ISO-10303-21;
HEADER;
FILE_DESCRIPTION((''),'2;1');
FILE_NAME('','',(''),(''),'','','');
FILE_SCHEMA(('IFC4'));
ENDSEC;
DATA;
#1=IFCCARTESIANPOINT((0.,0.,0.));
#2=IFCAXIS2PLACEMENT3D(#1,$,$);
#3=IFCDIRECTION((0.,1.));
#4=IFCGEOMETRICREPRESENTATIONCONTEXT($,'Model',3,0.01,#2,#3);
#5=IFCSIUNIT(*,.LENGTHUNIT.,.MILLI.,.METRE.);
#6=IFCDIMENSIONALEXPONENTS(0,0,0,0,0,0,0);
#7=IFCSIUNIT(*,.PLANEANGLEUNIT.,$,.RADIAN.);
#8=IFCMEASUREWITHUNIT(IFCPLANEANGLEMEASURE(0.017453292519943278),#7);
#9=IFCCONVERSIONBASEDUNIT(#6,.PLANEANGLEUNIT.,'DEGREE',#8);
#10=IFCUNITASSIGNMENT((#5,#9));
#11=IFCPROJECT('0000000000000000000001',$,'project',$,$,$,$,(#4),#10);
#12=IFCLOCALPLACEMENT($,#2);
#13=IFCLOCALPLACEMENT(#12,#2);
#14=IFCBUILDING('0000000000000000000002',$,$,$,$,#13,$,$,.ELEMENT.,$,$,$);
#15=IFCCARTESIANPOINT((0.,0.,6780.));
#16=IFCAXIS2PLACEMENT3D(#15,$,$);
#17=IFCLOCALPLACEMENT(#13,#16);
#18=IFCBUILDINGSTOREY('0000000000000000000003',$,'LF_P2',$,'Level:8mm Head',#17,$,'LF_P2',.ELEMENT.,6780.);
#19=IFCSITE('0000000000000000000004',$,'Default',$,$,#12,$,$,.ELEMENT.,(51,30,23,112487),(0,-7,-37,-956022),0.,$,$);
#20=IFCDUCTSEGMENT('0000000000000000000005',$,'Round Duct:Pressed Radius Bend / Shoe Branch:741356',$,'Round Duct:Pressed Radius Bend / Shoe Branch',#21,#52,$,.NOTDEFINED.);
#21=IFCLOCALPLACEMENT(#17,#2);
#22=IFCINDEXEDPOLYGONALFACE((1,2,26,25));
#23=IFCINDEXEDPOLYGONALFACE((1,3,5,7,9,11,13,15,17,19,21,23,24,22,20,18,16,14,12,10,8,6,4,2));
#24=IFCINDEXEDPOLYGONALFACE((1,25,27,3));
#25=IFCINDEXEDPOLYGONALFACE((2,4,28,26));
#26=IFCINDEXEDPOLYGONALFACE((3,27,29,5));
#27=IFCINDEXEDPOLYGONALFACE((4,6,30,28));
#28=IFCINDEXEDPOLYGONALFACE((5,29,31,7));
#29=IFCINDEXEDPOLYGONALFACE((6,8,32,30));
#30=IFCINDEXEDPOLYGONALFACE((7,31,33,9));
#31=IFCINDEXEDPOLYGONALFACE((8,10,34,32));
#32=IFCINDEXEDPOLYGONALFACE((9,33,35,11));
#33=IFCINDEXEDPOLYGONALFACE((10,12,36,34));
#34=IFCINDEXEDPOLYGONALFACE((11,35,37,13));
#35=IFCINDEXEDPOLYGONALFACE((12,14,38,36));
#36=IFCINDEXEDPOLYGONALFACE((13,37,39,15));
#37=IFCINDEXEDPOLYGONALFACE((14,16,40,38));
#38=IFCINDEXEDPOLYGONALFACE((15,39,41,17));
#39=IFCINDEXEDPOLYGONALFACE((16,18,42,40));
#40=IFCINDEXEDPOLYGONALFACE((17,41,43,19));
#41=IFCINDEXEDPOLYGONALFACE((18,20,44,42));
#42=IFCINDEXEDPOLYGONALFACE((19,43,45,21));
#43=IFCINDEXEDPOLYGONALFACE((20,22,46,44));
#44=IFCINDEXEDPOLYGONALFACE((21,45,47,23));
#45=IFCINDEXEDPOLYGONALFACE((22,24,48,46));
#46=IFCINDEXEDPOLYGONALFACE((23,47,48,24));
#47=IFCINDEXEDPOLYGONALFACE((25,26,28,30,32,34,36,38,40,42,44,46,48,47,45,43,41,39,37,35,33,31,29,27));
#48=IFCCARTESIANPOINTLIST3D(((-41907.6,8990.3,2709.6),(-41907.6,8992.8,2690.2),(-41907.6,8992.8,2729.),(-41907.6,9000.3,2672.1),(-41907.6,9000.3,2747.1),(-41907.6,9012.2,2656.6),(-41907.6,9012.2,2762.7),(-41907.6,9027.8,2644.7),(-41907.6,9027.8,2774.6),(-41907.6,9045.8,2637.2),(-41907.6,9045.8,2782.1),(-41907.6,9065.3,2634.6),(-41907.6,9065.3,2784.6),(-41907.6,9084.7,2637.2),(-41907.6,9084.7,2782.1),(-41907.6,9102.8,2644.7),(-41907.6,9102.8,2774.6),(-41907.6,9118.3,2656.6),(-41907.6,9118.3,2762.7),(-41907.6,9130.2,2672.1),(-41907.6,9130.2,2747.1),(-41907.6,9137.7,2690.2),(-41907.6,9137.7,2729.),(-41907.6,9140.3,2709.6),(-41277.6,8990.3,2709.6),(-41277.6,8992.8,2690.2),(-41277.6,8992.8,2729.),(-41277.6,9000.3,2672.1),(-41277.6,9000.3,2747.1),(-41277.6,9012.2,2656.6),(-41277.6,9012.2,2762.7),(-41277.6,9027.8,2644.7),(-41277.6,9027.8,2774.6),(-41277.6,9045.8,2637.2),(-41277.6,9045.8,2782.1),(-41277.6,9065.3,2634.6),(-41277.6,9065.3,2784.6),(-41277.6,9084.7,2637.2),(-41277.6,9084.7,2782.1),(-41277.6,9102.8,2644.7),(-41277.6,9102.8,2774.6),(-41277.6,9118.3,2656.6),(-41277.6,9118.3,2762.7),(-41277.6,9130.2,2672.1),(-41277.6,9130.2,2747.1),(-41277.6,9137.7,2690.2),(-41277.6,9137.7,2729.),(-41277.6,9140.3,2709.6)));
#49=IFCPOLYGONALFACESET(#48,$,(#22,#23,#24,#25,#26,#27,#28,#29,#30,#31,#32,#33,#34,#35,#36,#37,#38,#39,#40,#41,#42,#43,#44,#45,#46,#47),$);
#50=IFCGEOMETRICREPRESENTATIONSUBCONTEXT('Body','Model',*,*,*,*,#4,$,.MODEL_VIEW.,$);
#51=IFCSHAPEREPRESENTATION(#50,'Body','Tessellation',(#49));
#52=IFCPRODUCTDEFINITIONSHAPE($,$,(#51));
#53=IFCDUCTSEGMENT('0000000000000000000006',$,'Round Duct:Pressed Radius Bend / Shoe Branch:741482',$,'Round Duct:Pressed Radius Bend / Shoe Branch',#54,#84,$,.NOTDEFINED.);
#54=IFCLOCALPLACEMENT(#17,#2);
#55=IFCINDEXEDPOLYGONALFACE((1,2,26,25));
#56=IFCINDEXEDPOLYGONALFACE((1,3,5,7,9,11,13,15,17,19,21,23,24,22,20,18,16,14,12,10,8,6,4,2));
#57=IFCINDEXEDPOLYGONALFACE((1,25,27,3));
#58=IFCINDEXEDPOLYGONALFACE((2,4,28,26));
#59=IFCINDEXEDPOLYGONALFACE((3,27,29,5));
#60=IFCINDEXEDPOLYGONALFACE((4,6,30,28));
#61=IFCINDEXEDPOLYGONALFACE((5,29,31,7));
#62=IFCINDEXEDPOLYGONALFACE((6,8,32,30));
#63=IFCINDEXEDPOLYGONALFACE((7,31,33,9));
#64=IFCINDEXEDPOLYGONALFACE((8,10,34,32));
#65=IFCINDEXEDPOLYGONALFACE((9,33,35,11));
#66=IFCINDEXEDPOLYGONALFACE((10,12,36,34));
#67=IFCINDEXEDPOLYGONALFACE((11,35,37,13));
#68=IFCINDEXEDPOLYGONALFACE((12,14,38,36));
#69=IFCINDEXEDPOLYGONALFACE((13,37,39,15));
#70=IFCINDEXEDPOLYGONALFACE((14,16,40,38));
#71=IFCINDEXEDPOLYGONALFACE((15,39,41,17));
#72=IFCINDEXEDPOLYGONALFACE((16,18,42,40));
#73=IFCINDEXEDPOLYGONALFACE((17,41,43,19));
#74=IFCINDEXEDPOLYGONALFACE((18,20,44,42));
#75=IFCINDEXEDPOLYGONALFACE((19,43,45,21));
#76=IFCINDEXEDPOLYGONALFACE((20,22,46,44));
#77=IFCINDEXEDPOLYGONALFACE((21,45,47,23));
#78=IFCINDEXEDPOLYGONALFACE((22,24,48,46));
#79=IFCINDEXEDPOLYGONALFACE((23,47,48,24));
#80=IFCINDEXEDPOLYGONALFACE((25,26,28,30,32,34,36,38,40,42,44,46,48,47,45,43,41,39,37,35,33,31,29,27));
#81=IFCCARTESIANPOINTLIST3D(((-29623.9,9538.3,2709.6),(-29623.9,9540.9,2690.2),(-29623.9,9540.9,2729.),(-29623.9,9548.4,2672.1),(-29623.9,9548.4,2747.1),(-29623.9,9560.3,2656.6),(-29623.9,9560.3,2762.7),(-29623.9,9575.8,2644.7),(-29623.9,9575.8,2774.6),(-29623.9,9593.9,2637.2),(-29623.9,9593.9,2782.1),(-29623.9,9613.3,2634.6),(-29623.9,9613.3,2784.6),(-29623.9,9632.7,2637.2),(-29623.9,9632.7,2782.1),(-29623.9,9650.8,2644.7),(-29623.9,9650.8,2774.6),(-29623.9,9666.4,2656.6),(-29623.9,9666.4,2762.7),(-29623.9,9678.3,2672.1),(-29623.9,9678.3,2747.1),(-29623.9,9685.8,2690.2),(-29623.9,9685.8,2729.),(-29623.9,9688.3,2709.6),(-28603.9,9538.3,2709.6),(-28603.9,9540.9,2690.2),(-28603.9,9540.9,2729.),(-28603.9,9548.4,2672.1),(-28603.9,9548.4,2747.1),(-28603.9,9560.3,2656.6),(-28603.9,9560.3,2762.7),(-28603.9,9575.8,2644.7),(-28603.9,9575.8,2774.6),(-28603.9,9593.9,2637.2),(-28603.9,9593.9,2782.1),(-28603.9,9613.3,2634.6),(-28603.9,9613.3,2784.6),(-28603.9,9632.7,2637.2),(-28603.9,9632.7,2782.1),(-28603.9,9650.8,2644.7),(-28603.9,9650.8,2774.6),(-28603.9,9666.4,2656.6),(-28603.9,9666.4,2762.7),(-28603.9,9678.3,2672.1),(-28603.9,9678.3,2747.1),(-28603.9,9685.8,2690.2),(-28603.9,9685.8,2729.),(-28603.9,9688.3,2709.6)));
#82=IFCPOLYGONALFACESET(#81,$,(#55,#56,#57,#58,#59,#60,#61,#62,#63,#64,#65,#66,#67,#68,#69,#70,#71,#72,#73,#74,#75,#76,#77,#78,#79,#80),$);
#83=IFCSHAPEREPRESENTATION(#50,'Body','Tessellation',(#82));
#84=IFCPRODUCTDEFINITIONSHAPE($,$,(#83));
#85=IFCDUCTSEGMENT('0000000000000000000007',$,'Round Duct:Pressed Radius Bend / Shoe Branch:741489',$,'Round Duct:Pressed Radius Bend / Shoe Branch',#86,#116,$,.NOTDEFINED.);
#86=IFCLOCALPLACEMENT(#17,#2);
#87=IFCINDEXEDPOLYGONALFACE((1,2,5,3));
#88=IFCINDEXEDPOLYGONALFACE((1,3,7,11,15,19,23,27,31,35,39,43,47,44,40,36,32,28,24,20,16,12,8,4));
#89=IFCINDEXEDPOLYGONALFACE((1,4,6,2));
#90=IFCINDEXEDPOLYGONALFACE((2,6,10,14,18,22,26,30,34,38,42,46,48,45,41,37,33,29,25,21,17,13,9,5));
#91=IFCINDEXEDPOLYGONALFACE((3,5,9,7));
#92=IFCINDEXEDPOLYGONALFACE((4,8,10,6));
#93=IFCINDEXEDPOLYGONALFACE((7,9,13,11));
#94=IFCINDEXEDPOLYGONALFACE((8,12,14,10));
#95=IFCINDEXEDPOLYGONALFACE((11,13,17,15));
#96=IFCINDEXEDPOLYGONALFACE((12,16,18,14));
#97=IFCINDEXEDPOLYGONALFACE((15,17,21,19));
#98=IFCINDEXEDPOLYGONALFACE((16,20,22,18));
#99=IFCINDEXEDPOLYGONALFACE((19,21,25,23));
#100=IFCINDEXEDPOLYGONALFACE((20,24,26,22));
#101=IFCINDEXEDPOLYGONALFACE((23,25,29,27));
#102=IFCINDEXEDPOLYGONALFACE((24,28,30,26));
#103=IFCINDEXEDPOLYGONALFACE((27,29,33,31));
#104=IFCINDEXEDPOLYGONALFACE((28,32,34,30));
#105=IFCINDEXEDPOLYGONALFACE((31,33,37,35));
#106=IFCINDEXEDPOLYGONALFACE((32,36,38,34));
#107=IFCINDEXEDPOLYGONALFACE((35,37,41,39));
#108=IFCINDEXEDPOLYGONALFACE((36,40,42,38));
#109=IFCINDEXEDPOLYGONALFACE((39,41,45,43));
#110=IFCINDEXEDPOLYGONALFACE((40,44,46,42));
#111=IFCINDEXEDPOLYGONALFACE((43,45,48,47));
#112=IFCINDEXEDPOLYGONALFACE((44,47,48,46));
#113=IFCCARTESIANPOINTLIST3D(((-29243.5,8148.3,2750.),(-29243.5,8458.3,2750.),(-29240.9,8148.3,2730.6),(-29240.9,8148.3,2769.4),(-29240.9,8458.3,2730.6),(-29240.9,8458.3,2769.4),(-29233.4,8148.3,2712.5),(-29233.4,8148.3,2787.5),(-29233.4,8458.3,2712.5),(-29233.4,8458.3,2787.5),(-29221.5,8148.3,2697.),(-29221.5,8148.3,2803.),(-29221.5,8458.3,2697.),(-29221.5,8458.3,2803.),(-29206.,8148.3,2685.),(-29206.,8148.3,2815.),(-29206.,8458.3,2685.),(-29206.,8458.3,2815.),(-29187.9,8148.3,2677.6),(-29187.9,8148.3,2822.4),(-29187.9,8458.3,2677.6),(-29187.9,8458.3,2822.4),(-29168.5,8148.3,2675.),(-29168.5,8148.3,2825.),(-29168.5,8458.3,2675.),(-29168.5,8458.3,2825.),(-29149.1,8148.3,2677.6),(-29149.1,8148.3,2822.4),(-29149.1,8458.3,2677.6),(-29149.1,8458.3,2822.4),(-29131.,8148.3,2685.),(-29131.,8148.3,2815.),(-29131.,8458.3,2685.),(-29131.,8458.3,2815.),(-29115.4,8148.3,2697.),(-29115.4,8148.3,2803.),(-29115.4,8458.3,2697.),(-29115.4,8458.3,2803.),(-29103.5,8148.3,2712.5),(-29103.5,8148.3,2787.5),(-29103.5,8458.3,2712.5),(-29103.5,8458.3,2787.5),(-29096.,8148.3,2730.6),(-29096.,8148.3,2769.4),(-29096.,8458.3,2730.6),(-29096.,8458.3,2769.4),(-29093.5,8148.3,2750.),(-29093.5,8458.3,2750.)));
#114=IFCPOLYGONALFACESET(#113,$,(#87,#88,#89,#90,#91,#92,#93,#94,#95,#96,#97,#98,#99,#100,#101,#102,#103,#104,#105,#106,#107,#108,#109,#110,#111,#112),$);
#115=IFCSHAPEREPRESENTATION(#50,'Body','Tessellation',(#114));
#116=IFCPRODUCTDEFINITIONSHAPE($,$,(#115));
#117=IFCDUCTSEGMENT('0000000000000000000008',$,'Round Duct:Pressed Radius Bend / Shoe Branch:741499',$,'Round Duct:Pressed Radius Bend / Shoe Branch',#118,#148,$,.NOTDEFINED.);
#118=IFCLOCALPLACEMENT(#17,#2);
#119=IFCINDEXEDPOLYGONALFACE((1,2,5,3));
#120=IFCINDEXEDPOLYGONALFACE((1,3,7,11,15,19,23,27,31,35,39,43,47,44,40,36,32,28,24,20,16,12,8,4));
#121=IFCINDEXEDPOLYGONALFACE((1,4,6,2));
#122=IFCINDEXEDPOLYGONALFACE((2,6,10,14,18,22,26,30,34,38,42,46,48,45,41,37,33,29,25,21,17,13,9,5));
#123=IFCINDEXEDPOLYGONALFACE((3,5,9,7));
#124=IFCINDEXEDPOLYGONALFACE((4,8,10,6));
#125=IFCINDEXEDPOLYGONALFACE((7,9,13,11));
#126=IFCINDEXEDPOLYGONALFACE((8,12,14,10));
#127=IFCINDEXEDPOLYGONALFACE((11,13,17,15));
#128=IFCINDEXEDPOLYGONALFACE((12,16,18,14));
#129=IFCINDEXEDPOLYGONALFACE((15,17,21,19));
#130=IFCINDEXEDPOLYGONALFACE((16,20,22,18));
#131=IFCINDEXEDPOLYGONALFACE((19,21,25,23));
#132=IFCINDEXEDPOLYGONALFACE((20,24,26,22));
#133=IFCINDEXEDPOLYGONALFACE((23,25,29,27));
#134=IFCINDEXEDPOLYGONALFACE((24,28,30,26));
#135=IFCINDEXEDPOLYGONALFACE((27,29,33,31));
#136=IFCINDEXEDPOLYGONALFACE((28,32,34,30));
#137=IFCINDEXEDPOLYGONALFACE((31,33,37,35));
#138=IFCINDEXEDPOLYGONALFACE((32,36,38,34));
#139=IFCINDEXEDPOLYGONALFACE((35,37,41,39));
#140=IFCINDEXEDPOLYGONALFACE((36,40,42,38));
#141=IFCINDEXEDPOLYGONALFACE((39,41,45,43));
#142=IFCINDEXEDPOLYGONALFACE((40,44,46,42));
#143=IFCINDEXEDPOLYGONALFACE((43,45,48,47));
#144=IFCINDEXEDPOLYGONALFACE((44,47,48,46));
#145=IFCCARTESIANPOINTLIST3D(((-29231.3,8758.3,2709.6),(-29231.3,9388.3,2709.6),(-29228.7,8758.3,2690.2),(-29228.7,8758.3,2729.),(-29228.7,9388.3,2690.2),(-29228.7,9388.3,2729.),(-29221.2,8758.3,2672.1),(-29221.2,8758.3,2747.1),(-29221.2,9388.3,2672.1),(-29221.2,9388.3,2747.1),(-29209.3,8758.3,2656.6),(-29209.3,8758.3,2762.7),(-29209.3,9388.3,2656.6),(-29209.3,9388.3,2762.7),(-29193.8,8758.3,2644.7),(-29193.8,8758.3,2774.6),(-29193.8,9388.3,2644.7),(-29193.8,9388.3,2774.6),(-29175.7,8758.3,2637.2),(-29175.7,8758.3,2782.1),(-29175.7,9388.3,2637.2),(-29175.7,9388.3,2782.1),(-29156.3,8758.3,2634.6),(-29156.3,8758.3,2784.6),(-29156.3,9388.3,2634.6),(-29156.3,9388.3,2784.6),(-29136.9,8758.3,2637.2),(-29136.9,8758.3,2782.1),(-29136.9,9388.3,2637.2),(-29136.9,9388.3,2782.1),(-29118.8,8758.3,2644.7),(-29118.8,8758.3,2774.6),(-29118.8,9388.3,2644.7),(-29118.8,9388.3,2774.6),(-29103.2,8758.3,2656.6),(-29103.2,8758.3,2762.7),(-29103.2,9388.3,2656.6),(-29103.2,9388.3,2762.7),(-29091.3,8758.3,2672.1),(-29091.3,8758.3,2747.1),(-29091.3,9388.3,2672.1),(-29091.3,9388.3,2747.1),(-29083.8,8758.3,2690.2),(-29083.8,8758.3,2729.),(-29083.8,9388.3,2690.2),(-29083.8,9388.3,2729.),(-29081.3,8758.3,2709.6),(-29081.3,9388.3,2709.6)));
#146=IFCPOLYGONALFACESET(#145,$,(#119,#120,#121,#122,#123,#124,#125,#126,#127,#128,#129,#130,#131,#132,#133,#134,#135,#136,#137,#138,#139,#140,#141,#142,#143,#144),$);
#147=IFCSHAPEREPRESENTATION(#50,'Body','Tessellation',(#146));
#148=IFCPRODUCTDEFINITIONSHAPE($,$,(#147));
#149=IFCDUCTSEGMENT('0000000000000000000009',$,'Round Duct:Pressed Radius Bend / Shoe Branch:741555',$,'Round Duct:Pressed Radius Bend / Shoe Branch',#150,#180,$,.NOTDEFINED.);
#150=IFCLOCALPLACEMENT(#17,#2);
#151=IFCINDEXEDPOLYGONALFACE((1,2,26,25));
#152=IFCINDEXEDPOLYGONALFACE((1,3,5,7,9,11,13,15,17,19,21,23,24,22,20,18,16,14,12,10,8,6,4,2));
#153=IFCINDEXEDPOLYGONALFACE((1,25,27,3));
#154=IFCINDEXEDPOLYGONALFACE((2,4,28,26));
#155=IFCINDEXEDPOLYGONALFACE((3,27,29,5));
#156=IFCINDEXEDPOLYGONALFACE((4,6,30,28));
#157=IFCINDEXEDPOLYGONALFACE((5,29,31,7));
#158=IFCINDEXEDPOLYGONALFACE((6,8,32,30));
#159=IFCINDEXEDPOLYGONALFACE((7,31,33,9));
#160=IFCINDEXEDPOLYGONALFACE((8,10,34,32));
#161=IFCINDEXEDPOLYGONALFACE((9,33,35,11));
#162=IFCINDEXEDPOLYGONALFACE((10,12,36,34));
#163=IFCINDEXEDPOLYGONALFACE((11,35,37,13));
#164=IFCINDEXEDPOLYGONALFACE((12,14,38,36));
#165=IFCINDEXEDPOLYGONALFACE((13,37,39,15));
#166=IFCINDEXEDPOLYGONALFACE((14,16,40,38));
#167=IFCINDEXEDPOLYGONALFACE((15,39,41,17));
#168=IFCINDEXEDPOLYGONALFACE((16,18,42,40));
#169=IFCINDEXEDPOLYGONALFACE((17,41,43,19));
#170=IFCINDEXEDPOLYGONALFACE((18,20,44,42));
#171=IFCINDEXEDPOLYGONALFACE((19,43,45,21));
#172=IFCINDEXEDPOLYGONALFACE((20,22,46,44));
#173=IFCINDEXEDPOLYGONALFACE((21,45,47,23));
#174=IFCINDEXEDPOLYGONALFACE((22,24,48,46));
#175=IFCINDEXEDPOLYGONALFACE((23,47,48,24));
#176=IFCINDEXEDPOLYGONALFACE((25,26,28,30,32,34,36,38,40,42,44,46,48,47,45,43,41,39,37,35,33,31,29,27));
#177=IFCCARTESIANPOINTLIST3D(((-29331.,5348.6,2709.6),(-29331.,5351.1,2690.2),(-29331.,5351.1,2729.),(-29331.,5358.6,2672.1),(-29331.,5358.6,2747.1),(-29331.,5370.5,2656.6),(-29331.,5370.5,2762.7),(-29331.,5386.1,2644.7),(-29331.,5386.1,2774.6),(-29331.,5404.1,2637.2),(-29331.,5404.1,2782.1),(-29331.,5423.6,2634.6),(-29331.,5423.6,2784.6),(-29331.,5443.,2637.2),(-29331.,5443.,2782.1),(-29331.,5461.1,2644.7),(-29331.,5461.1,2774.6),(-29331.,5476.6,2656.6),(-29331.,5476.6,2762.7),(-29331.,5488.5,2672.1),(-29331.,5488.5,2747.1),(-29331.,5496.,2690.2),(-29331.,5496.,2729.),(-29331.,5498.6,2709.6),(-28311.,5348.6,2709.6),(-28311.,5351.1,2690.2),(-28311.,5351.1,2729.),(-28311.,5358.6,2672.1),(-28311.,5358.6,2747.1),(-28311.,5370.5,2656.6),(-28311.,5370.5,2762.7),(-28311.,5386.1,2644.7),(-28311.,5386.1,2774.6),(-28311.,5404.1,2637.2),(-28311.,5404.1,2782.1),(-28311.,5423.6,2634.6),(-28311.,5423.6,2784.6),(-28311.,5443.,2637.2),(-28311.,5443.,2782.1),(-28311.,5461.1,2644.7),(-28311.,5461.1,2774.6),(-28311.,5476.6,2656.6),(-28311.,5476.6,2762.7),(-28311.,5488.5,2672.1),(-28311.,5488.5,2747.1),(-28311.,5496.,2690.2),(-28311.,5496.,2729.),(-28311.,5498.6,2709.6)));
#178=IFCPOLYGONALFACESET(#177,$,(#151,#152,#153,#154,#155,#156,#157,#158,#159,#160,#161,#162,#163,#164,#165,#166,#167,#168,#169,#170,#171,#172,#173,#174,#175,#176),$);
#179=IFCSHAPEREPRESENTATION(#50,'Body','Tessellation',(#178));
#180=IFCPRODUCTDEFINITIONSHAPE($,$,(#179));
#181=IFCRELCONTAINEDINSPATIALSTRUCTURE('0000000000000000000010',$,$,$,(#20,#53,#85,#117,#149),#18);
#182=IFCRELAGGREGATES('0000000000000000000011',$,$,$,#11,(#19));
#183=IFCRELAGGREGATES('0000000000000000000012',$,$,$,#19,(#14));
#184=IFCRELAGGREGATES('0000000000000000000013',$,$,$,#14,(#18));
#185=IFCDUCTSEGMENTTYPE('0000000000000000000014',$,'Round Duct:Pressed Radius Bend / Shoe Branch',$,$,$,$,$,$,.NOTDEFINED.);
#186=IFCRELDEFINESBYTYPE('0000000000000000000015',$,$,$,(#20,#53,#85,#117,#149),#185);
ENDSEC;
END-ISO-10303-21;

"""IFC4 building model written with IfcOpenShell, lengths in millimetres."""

from ifc_helpers import new_model, entity, si_unit, converted_unit, direction, frame, origin, place, context, subcontext, project, spatial, arc, indexed_curve, outline, extrude, type_object, element, save


model = new_model("IFC4")

# Units and contexts
model_context = context("Model", 3, precision=0.01, world=origin(), true_north=direction((0.0, 1.0)))
body_context = subcontext(model_context, "Body", "Model", "MODEL_VIEW")
ifc_project = project(units=[si_unit("LENGTHUNIT", "METRE", prefix="MILLI"), converted_unit("PLANEANGLEUNIT", "DEGREE", entity("IfcPlaneAngleMeasure", 0.017453292519943278), si_unit("PLANEANGLEUNIT", "RADIAN"), dimensions=[0, 0, 0, 0, 0, 0, 0])], contexts=[model_context])

# Site, building, storey
site_placement = place(None, origin())
site = spatial("IfcSite", under=ifc_project, at=site_placement, Name="Default", CompositionType="ELEMENT", RefLatitude=(51, 30, 23, 112487), RefLongitude=(0, -7, -37, -956022), RefElevation=0.0)
building_placement = place(site_placement, origin())
building = spatial("IfcBuilding", under=site, at=building_placement, CompositionType="ELEMENT")
storey_placement = place(building_placement, frame((0.0, 0.0, 6780.0)))
storey = spatial("IfcBuildingStorey", under=building, at=storey_placement, Name="LF_P2", ObjectType="Level:8mm Head", LongName="LF_P2", CompositionType="ELEMENT", Elevation=6780.0)

# Duct segments
duct_segment_type_1 = type_object("IfcDuctSegmentType", Name="Round Duct:Pressed Radius Bend / Shoe Branch", PredefinedType="NOTDEFINED")
duct_segment_1_placement = place(storey_placement, origin())
element("IfcDuctSegment", 1, at=duct_segment_1_placement, inside=storey, type_object=duct_segment_type_1, Name="Round Duct:Pressed Radius Bend / Shoe Branch:741356", ObjectType="Round Duct:Pressed Radius Bend / Shoe Branch", PredefinedType="NOTDEFINED", context=body_context, shape_type="SweptSolid", body=[
    extrude(outline(indexed_curve([(75.0, 0.0), (53.0, 53.0), (0.0, 75.0), (-53.0, 53.0), (-75.0, 0.0), (-53.0, -53.0), (0.0, -75.0), (53.0, -53.0)], segments=[arc(1, 2, 3), arc(3, 4, 5), arc(5, 6, 7), arc(7, 8, 1)], self_intersect=False)), frame((-41907.6, 9065.3, 2709.6), z_axis=(1.0, 0.0, 0.0), x_axis=(0.0, 1.0, 0.0)), (0.0, 0.0, 1.0), 630.0),
])
duct_segment_2_placement = place(storey_placement, origin())
element("IfcDuctSegment", 2, at=duct_segment_2_placement, inside=storey, type_object=duct_segment_type_1, Name="Round Duct:Pressed Radius Bend / Shoe Branch:741482", ObjectType="Round Duct:Pressed Radius Bend / Shoe Branch", PredefinedType="NOTDEFINED", context=body_context, shape_type="SweptSolid", body=[
    extrude(outline(indexed_curve([(75.0, 0.0), (53.0, 53.0), (0.0, 75.0), (-53.0, 53.0), (-75.0, 0.0), (-53.0, -53.0), (0.0, -75.0), (53.0, -53.0)], segments=[arc(1, 2, 3), arc(3, 4, 5), arc(5, 6, 7), arc(7, 8, 1)], self_intersect=False)), frame((-29623.9, 9613.3, 2709.6), z_axis=(1.0, 0.0, 0.0), x_axis=(0.0, -1.0, 0.0)), (0.0, 0.0, 1.0), 1020.0),
])
duct_segment_3_placement = place(storey_placement, origin())
element("IfcDuctSegment", 3, at=duct_segment_3_placement, inside=storey, type_object=duct_segment_type_1, Name="Round Duct:Pressed Radius Bend / Shoe Branch:741489", ObjectType="Round Duct:Pressed Radius Bend / Shoe Branch", PredefinedType="NOTDEFINED", context=body_context, shape_type="SweptSolid", body=[
    extrude(outline(indexed_curve([(75.0, 0.0), (53.0, 53.0), (0.0, 75.0), (-53.0, 53.0), (-75.0, 0.0), (-53.0, -53.0), (0.0, -75.0), (53.0, -53.0)], segments=[arc(1, 2, 3), arc(3, 4, 5), arc(5, 6, 7), arc(7, 8, 1)], self_intersect=False)), frame((-29168.5, 8148.3, 2750.0), z_axis=(0.0, 1.0, 0.0), x_axis=(1.0, 0.0, 0.0)), (0.0, 0.0, 1.0), 310.0),
])
duct_segment_4_placement = place(storey_placement, origin())
element("IfcDuctSegment", 4, at=duct_segment_4_placement, inside=storey, type_object=duct_segment_type_1, Name="Round Duct:Pressed Radius Bend / Shoe Branch:741499", ObjectType="Round Duct:Pressed Radius Bend / Shoe Branch", PredefinedType="NOTDEFINED", context=body_context, shape_type="SweptSolid", body=[
    extrude(outline(indexed_curve([(75.0, 0.0), (53.0, 53.0), (0.0, 75.0), (-53.0, 53.0), (-75.0, 0.0), (-53.0, -53.0), (0.0, -75.0), (53.0, -53.0)], segments=[arc(1, 2, 3), arc(3, 4, 5), arc(5, 6, 7), arc(7, 8, 1)], self_intersect=False)), frame((-29156.3, 8758.3, 2709.6), z_axis=(0.0, 1.0, 0.0), x_axis=(-1.0, 0.0, 0.0)), (0.0, 0.0, 1.0), 630.0),
])
duct_segment_5_placement = place(storey_placement, origin())
element("IfcDuctSegment", 5, at=duct_segment_5_placement, inside=storey, type_object=duct_segment_type_1, Name="Round Duct:Pressed Radius Bend / Shoe Branch:741555", ObjectType="Round Duct:Pressed Radius Bend / Shoe Branch", PredefinedType="NOTDEFINED", context=body_context, shape_type="SweptSolid", body=[
    extrude(outline(indexed_curve([(75.0, 0.0), (53.0, 53.0), (0.0, 75.0), (-53.0, 53.0), (-75.0, 0.0), (-53.0, -53.0), (0.0, -75.0), (53.0, -53.0)], segments=[arc(1, 2, 3), arc(3, 4, 5), arc(5, 6, 7), arc(7, 8, 1)], self_intersect=False)), frame((-29331.0, 5423.6, 2709.6), z_axis=(1.0, 0.0, 0.0), x_axis=(0.0, -1.0, 0.0)), (0.0, 0.0, 1.0), 1020.0),
])

save(model, "model.ifc")
